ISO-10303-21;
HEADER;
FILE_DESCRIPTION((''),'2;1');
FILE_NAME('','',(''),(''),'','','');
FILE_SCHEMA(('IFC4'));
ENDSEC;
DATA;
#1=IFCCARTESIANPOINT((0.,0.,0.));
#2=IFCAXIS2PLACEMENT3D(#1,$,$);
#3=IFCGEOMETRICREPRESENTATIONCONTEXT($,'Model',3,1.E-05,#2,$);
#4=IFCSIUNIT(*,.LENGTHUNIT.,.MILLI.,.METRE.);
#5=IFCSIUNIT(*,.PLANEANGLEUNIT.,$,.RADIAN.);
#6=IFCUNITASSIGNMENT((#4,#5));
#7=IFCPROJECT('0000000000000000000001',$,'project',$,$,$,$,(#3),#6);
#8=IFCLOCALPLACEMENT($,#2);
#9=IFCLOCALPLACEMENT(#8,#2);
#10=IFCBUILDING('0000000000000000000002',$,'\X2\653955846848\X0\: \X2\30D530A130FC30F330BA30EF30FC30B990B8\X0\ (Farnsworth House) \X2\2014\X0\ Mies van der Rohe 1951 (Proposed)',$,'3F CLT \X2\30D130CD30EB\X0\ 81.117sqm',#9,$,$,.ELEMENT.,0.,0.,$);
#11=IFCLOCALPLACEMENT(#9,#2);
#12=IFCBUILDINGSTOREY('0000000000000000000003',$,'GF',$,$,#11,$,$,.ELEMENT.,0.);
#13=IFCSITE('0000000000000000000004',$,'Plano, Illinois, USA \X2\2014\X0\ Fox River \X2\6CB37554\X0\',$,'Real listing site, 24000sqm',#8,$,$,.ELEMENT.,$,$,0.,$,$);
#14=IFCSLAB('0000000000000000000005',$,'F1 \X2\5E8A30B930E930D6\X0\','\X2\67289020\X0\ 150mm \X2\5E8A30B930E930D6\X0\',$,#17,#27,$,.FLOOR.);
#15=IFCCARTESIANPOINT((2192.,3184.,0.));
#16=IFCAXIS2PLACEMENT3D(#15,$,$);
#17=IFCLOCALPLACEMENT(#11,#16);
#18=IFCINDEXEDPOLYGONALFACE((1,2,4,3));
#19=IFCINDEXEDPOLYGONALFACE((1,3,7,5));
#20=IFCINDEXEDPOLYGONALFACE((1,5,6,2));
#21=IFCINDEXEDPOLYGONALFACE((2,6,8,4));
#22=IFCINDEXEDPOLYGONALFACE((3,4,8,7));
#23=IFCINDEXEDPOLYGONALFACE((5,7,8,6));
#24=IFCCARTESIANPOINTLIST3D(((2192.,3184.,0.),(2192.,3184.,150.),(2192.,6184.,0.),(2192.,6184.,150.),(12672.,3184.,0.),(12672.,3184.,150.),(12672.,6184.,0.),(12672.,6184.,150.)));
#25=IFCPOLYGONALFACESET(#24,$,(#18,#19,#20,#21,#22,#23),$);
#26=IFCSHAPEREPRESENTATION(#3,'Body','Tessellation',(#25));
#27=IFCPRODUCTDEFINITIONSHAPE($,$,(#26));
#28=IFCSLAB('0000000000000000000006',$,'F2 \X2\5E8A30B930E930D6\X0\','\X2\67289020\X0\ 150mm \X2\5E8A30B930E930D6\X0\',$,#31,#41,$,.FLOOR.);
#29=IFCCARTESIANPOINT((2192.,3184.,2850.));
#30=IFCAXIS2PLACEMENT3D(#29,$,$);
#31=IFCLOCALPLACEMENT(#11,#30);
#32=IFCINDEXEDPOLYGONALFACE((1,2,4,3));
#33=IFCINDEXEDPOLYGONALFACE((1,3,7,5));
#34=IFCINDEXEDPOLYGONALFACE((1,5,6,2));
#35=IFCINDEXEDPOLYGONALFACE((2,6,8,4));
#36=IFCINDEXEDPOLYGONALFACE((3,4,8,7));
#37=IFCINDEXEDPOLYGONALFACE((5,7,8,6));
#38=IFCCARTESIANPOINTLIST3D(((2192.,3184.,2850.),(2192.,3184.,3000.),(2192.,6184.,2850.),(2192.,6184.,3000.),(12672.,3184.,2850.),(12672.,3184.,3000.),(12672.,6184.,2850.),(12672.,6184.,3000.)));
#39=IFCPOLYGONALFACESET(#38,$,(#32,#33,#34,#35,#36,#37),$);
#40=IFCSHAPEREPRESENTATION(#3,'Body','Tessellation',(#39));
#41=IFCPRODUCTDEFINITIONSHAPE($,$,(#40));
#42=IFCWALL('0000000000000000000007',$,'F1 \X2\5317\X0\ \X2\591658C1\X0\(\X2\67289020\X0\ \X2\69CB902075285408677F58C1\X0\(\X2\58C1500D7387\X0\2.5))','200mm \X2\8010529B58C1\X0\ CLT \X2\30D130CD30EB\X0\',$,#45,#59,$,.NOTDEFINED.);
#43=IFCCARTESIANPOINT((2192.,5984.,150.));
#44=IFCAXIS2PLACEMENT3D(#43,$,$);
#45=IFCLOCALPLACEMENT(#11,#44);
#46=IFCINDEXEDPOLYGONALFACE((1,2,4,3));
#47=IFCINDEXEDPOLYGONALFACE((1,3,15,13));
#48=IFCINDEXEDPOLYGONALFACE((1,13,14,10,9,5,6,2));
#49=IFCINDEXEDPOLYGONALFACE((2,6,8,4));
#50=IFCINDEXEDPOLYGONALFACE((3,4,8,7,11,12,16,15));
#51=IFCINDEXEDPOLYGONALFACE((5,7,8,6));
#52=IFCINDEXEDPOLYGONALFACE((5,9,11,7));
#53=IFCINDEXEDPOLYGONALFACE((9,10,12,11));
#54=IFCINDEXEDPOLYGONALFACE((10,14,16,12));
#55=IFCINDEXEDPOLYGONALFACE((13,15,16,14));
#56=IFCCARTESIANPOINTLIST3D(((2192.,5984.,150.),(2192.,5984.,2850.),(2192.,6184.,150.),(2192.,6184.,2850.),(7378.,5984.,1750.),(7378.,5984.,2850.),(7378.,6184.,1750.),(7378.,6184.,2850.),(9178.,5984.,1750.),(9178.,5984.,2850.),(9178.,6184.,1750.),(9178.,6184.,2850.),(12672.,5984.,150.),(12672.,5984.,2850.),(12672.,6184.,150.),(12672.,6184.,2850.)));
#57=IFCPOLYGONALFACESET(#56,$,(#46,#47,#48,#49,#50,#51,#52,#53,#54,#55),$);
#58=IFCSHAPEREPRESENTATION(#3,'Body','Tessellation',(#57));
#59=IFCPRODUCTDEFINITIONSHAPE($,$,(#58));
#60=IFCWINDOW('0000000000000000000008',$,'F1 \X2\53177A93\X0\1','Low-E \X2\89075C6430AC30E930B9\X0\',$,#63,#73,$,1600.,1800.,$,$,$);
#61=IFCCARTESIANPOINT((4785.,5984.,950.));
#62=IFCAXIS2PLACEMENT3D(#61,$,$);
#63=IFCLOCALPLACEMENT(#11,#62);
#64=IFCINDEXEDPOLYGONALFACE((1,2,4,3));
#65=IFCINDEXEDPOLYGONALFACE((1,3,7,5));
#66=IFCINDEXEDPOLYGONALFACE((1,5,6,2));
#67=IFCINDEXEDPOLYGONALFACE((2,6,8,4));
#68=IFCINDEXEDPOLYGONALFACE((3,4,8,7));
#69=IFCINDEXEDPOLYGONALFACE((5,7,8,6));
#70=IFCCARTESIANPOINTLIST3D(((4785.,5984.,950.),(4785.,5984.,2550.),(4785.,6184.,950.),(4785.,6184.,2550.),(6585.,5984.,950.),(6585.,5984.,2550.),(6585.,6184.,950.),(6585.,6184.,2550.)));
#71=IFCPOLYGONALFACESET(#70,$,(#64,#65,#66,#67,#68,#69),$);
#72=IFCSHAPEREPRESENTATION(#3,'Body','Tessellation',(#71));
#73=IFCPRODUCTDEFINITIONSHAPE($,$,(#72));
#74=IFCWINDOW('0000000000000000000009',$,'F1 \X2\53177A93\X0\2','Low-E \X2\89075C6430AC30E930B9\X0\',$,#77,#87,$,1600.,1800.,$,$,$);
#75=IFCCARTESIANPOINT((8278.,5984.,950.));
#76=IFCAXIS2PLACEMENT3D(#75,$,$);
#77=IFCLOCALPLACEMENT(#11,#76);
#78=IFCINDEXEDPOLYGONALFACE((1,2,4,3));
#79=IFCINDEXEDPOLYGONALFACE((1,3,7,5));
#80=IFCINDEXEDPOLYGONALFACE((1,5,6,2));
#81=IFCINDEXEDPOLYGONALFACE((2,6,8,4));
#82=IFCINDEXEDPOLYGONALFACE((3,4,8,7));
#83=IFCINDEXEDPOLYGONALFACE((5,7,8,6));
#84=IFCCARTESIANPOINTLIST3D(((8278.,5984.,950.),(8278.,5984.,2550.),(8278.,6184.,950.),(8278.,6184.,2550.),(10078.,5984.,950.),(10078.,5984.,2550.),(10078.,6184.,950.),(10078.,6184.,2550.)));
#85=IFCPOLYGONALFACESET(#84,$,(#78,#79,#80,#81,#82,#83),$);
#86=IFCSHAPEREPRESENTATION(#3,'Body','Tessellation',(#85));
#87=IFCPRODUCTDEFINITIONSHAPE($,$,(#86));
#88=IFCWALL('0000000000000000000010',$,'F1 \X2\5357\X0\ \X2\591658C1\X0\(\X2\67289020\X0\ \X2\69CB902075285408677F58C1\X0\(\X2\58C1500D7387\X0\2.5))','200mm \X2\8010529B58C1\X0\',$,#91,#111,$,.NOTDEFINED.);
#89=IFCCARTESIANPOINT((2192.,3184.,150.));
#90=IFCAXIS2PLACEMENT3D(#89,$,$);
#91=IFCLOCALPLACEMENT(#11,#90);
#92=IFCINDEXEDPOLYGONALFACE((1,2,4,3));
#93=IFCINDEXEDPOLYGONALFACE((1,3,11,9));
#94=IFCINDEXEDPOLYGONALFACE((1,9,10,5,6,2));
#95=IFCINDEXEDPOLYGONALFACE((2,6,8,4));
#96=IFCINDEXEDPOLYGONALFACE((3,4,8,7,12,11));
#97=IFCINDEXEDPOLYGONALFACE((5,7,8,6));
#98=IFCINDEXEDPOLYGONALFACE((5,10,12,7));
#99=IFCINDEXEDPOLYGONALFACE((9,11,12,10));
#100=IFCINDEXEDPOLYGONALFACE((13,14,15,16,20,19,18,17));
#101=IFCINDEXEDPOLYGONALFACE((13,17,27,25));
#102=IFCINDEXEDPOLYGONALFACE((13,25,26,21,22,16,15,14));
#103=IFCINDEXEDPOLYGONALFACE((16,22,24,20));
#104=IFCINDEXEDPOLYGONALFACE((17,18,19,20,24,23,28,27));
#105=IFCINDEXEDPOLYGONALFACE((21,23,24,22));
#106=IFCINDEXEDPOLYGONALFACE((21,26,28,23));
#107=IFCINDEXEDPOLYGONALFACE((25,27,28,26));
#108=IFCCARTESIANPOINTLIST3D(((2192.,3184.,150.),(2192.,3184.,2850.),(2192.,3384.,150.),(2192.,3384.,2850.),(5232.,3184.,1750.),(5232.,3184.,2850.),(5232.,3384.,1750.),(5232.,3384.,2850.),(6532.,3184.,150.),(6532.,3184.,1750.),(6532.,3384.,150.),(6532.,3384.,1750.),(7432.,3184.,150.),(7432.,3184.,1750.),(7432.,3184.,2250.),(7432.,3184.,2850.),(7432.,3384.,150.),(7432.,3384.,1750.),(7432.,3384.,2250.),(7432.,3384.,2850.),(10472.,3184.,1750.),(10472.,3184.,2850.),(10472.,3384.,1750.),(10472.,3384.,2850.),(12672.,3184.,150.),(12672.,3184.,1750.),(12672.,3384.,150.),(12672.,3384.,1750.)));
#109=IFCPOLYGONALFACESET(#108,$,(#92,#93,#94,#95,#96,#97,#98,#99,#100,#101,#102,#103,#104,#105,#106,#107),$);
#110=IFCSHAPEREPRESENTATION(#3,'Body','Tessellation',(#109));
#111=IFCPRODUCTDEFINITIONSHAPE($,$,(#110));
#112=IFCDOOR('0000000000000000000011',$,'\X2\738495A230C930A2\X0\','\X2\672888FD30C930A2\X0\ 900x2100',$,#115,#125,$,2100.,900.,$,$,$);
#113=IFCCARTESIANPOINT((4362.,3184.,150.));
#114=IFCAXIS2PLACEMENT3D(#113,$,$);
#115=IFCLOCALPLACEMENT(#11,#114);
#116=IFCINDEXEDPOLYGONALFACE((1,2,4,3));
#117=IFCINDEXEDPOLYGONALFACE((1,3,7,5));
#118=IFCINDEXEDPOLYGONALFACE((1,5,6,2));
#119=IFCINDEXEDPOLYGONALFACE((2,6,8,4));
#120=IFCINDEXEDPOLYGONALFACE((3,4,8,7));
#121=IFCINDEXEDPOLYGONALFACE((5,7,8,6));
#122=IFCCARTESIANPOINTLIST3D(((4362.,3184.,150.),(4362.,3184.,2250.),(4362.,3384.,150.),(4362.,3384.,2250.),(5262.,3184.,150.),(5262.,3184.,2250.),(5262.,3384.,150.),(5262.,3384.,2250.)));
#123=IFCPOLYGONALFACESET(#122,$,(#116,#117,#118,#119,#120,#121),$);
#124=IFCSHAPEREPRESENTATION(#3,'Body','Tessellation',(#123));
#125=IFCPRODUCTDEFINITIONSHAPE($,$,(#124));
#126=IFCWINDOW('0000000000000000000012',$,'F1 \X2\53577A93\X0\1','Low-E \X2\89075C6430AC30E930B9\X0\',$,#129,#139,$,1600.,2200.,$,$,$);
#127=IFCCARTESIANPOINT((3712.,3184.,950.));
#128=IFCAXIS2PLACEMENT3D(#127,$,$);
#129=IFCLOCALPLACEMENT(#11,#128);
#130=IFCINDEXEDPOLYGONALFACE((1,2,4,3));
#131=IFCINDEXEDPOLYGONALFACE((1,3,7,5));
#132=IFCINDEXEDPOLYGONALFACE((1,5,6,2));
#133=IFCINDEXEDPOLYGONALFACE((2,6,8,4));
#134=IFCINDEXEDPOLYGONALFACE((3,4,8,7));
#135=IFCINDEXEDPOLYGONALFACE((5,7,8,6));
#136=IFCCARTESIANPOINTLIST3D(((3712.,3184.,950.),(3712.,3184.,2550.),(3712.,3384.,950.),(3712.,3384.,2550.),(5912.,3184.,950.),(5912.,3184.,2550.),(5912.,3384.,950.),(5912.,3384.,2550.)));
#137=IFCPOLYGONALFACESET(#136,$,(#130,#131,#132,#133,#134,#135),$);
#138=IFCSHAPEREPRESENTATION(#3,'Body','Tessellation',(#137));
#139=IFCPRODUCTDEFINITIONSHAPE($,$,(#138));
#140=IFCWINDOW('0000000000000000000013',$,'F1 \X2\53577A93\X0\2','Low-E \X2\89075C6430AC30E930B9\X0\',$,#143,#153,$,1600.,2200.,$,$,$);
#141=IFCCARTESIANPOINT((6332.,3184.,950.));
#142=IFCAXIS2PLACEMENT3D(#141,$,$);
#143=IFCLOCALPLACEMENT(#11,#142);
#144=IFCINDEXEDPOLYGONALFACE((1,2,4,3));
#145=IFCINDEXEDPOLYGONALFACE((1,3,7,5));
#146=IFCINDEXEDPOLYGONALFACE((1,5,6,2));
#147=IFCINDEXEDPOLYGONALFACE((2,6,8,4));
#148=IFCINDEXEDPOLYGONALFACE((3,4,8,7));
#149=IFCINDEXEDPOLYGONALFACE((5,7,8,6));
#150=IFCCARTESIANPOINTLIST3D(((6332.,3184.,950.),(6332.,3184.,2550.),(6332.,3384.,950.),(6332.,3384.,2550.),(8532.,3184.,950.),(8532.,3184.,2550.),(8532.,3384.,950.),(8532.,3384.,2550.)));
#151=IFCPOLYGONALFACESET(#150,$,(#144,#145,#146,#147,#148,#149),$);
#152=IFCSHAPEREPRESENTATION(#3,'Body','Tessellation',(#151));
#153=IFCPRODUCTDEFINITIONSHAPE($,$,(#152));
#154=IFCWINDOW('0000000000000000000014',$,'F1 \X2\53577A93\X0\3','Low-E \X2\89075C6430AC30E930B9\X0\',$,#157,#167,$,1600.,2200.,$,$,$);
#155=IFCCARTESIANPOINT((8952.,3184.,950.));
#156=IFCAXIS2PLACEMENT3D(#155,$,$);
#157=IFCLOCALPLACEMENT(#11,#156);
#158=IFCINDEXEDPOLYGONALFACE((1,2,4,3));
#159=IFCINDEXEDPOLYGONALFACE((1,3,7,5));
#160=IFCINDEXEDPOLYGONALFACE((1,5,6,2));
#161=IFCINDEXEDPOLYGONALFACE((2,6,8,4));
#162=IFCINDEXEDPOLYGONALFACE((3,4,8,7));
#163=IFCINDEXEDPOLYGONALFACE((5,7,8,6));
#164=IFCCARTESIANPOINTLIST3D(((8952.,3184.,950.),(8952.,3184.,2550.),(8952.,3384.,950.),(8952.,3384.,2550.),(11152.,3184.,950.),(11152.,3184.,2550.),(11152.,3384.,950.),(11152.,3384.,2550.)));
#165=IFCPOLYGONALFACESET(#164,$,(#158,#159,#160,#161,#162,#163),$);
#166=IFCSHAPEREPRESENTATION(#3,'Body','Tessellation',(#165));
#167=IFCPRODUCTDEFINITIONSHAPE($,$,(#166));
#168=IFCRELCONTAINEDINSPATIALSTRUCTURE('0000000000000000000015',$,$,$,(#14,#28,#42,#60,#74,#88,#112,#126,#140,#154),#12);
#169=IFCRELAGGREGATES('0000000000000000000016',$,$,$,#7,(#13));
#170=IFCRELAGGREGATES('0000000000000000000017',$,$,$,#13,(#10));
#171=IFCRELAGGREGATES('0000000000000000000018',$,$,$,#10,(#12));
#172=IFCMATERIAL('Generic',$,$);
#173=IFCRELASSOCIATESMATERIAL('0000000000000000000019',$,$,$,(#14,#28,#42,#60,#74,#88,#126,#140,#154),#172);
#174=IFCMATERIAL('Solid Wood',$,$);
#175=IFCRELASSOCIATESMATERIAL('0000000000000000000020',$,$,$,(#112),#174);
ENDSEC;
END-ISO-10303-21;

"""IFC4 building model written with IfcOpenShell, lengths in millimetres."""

from ifc_helpers import new_model, si_unit, frame, frame_2d, origin, place, context, project, spatial, rectangle, extrude, material, element, fill, save


model = new_model("IFC4")

# Units and contexts
model_context = context("Model", 3, precision=1e-05, world=origin())
ifc_project = project(units=[si_unit("LENGTHUNIT", "METRE", prefix="MILLI"), si_unit("PLANEANGLEUNIT", "RADIAN")], contexts=[model_context])

# Site, building, storey
site_placement = place(None, origin())
site = spatial("IfcSite", under=ifc_project, at=site_placement, Name="Plano, Illinois, USA — Fox River 河畔", ObjectType="Real listing site, 24000sqm", CompositionType="ELEMENT", RefElevation=0.0)
building_placement = place(site_placement, origin())
building = spatial("IfcBuilding", under=site, at=building_placement, Name="改善案: ファーンズワース邸 (Farnsworth House) — Mies van der Rohe 1951 (Proposed)", ObjectType="3F CLT パネル 81.117sqm", CompositionType="ELEMENT", ElevationOfRefHeight=0.0, ElevationOfTerrain=0.0)
storey_placement = place(building_placement, origin())
storey = spatial("IfcBuildingStorey", under=building, at=storey_placement, Name="GF", CompositionType="ELEMENT", Elevation=0.0)

# Slabs
ifc_material_1 = material(Name="Generic")
slab_1_placement = place(storey_placement, frame((2192.0, 3184.0, 0.0)))
element("IfcSlab", 1, at=slab_1_placement, inside=storey, material=ifc_material_1, Name="F1 床スラブ", Description="木造 150mm 床スラブ", PredefinedType="FLOOR", context=model_context, shape_type="SweptSolid", body=[
    extrude(rectangle(XDim=10480.0, YDim=3000.0, at=frame_2d((5240.0, 1500.0))), frame((2192.0, 3184.0, 0.0)), (0.0, 0.0, 1.0), 150.0),
])
slab_2_placement = place(storey_placement, frame((2192.0, 3184.0, 2850.0)))
element("IfcSlab", 2, at=slab_2_placement, inside=storey, material=ifc_material_1, Name="F2 床スラブ", Description="木造 150mm 床スラブ", PredefinedType="FLOOR", context=model_context, shape_type="SweptSolid", body=[
    extrude(rectangle(XDim=10480.0, YDim=3000.0, at=frame_2d((5240.0, 1500.0))), frame((2192.0, 3184.0, 2850.0)), (0.0, 0.0, 1.0), 150.0),
])

# Wall, openings, windows
wall_1_placement = place(storey_placement, frame((2192.0, 5984.0, 150.0)))
wall_1 = element("IfcWall", 3, at=wall_1_placement, inside=storey, material=ifc_material_1, Name="F1 北 外壁(木造 構造用合板壁(壁倍率2.5))", Description="200mm 耐力壁 CLT パネル", PredefinedType="NOTDEFINED", context=model_context, shape_type="SweptSolid", body=[
    extrude(rectangle(XDim=10480.0, YDim=200.0, at=frame_2d((5240.0, 100.0))), frame((2192.0, 5984.0, 150.0)), (0.0, 0.0, 1.0), 2700.0),
])
opening_1_placement = place(storey_placement, frame((4785.0, 5984.0, 950.0)))
opening_1 = element("IfcOpeningElement", 4, at=opening_1_placement, cuts=wall_1, PredefinedType="NOTDEFINED", context=model_context, shape_type="SweptSolid", body=[
    extrude(rectangle(XDim=1800.0, YDim=200.0, at=frame_2d((900.0, 100.0))), frame((4785.0, 5984.0, 950.0)), (0.0, 0.0, 1.0), 1600.0),
])
opening_2_placement = place(storey_placement, frame((8278.0, 5984.0, 950.0)))
opening_2 = element("IfcOpeningElement", 5, at=opening_2_placement, cuts=wall_1, PredefinedType="NOTDEFINED", context=model_context, shape_type="SweptSolid", body=[
    extrude(rectangle(XDim=1800.0, YDim=200.0, at=frame_2d((900.0, 100.0))), frame((8278.0, 5984.0, 950.0)), (0.0, 0.0, 1.0), 1600.0),
])
window_1_placement = place(storey_placement, frame((4785.0, 5984.0, 950.0)))
window_1 = element("IfcWindow", 6, at=window_1_placement, inside=storey, material=ifc_material_1, Name="F1 北窓1", Description="Low-E 複層ガラス", OverallHeight=1600.0, OverallWidth=1800.0, context=model_context, shape_type="SweptSolid", body=[
    extrude(rectangle(XDim=1800.0, YDim=200.0, at=frame_2d((900.0, 100.0))), frame((4785.0, 5984.0, 950.0)), (0.0, 0.0, 1.0), 1600.0),
])
fill(opening_1, window_1)
window_2_placement = place(storey_placement, frame((8278.0, 5984.0, 950.0)))
window_2 = element("IfcWindow", 7, at=window_2_placement, inside=storey, material=ifc_material_1, Name="F1 北窓2", Description="Low-E 複層ガラス", OverallHeight=1600.0, OverallWidth=1800.0, context=model_context, shape_type="SweptSolid", body=[
    extrude(rectangle(XDim=1800.0, YDim=200.0, at=frame_2d((900.0, 100.0))), frame((8278.0, 5984.0, 950.0)), (0.0, 0.0, 1.0), 1600.0),
])
fill(opening_2, window_2)

# Wall, openings, door, windows
wall_2_placement = place(storey_placement, frame((2192.0, 3184.0, 150.0)))
wall_2 = element("IfcWall", 8, at=wall_2_placement, inside=storey, material=ifc_material_1, Name="F1 南 外壁(木造 構造用合板壁(壁倍率2.5))", Description="200mm 耐力壁", PredefinedType="NOTDEFINED", context=model_context, shape_type="SweptSolid", body=[
    extrude(rectangle(XDim=10480.0, YDim=200.0, at=frame_2d((5240.0, 100.0))), frame((2192.0, 3184.0, 150.0)), (0.0, 0.0, 1.0), 2700.0),
])
opening_3_placement = place(storey_placement, frame((4362.0, 3184.0, 150.0)))
opening_3 = element("IfcOpeningElement", 9, at=opening_3_placement, cuts=wall_2, PredefinedType="NOTDEFINED", context=model_context, shape_type="SweptSolid", body=[
    extrude(rectangle(XDim=900.0, YDim=200.0, at=frame_2d((450.0, 100.0))), frame((4362.0, 3184.0, 150.0)), (0.0, 0.0, 1.0), 2100.0),
])
opening_4_placement = place(storey_placement, frame((3712.0, 3184.0, 950.0)))
opening_4 = element("IfcOpeningElement", 10, at=opening_4_placement, cuts=wall_2, PredefinedType="NOTDEFINED", context=model_context, shape_type="SweptSolid", body=[
    extrude(rectangle(XDim=2200.0, YDim=200.0, at=frame_2d((1100.0, 100.0))), frame((3712.0, 3184.0, 950.0)), (0.0, 0.0, 1.0), 1600.0),
])
opening_5_placement = place(storey_placement, frame((6332.0, 3184.0, 950.0)))
opening_5 = element("IfcOpeningElement", 11, at=opening_5_placement, cuts=wall_2, PredefinedType="NOTDEFINED", context=model_context, shape_type="SweptSolid", body=[
    extrude(rectangle(XDim=2200.0, YDim=200.0, at=frame_2d((1100.0, 100.0))), frame((6332.0, 3184.0, 950.0)), (0.0, 0.0, 1.0), 1600.0),
])
opening_6_placement = place(storey_placement, frame((8952.0, 3184.0, 950.0)))
opening_6 = element("IfcOpeningElement", 12, at=opening_6_placement, cuts=wall_2, PredefinedType="NOTDEFINED", context=model_context, shape_type="SweptSolid", body=[
    extrude(rectangle(XDim=2200.0, YDim=200.0, at=frame_2d((1100.0, 100.0))), frame((8952.0, 3184.0, 950.0)), (0.0, 0.0, 1.0), 1600.0),
])
ifc_material_2 = material(Name="Solid Wood")
door_placement = place(storey_placement, frame((4362.0, 3184.0, 150.0)))
door = element("IfcDoor", 13, at=door_placement, inside=storey, material=ifc_material_2, Name="玄関ドア", Description="木製ドア 900x2100", OverallHeight=2100.0, OverallWidth=900.0, context=model_context, shape_type="SweptSolid", body=[
    extrude(rectangle(XDim=900.0, YDim=200.0, at=frame_2d((450.0, 100.0))), frame((4362.0, 3184.0, 150.0)), (0.0, 0.0, 1.0), 2100.0),
])
fill(opening_3, door)
window_3_placement = place(storey_placement, frame((3712.0, 3184.0, 950.0)))
window_3 = element("IfcWindow", 14, at=window_3_placement, inside=storey, material=ifc_material_1, Name="F1 南窓1", Description="Low-E 複層ガラス", OverallHeight=1600.0, OverallWidth=2200.0, context=model_context, shape_type="SweptSolid", body=[
    extrude(rectangle(XDim=2200.0, YDim=200.0, at=frame_2d((1100.0, 100.0))), frame((3712.0, 3184.0, 950.0)), (0.0, 0.0, 1.0), 1600.0),
])
fill(opening_4, window_3)
window_4_placement = place(storey_placement, frame((6332.0, 3184.0, 950.0)))
window_4 = element("IfcWindow", 15, at=window_4_placement, inside=storey, material=ifc_material_1, Name="F1 南窓2", Description="Low-E 複層ガラス", OverallHeight=1600.0, OverallWidth=2200.0, context=model_context, shape_type="SweptSolid", body=[
    extrude(rectangle(XDim=2200.0, YDim=200.0, at=frame_2d((1100.0, 100.0))), frame((6332.0, 3184.0, 950.0)), (0.0, 0.0, 1.0), 1600.0),
])
fill(opening_5, window_4)
window_5_placement = place(storey_placement, frame((8952.0, 3184.0, 950.0)))
window_5 = element("IfcWindow", 16, at=window_5_placement, inside=storey, material=ifc_material_1, Name="F1 南窓3", Description="Low-E 複層ガラス", OverallHeight=1600.0, OverallWidth=2200.0, context=model_context, shape_type="SweptSolid", body=[
    extrude(rectangle(XDim=2200.0, YDim=200.0, at=frame_2d((1100.0, 100.0))), frame((8952.0, 3184.0, 950.0)), (0.0, 0.0, 1.0), 1600.0),
])
fill(opening_6, window_5)

save(model, "model.ifc")
